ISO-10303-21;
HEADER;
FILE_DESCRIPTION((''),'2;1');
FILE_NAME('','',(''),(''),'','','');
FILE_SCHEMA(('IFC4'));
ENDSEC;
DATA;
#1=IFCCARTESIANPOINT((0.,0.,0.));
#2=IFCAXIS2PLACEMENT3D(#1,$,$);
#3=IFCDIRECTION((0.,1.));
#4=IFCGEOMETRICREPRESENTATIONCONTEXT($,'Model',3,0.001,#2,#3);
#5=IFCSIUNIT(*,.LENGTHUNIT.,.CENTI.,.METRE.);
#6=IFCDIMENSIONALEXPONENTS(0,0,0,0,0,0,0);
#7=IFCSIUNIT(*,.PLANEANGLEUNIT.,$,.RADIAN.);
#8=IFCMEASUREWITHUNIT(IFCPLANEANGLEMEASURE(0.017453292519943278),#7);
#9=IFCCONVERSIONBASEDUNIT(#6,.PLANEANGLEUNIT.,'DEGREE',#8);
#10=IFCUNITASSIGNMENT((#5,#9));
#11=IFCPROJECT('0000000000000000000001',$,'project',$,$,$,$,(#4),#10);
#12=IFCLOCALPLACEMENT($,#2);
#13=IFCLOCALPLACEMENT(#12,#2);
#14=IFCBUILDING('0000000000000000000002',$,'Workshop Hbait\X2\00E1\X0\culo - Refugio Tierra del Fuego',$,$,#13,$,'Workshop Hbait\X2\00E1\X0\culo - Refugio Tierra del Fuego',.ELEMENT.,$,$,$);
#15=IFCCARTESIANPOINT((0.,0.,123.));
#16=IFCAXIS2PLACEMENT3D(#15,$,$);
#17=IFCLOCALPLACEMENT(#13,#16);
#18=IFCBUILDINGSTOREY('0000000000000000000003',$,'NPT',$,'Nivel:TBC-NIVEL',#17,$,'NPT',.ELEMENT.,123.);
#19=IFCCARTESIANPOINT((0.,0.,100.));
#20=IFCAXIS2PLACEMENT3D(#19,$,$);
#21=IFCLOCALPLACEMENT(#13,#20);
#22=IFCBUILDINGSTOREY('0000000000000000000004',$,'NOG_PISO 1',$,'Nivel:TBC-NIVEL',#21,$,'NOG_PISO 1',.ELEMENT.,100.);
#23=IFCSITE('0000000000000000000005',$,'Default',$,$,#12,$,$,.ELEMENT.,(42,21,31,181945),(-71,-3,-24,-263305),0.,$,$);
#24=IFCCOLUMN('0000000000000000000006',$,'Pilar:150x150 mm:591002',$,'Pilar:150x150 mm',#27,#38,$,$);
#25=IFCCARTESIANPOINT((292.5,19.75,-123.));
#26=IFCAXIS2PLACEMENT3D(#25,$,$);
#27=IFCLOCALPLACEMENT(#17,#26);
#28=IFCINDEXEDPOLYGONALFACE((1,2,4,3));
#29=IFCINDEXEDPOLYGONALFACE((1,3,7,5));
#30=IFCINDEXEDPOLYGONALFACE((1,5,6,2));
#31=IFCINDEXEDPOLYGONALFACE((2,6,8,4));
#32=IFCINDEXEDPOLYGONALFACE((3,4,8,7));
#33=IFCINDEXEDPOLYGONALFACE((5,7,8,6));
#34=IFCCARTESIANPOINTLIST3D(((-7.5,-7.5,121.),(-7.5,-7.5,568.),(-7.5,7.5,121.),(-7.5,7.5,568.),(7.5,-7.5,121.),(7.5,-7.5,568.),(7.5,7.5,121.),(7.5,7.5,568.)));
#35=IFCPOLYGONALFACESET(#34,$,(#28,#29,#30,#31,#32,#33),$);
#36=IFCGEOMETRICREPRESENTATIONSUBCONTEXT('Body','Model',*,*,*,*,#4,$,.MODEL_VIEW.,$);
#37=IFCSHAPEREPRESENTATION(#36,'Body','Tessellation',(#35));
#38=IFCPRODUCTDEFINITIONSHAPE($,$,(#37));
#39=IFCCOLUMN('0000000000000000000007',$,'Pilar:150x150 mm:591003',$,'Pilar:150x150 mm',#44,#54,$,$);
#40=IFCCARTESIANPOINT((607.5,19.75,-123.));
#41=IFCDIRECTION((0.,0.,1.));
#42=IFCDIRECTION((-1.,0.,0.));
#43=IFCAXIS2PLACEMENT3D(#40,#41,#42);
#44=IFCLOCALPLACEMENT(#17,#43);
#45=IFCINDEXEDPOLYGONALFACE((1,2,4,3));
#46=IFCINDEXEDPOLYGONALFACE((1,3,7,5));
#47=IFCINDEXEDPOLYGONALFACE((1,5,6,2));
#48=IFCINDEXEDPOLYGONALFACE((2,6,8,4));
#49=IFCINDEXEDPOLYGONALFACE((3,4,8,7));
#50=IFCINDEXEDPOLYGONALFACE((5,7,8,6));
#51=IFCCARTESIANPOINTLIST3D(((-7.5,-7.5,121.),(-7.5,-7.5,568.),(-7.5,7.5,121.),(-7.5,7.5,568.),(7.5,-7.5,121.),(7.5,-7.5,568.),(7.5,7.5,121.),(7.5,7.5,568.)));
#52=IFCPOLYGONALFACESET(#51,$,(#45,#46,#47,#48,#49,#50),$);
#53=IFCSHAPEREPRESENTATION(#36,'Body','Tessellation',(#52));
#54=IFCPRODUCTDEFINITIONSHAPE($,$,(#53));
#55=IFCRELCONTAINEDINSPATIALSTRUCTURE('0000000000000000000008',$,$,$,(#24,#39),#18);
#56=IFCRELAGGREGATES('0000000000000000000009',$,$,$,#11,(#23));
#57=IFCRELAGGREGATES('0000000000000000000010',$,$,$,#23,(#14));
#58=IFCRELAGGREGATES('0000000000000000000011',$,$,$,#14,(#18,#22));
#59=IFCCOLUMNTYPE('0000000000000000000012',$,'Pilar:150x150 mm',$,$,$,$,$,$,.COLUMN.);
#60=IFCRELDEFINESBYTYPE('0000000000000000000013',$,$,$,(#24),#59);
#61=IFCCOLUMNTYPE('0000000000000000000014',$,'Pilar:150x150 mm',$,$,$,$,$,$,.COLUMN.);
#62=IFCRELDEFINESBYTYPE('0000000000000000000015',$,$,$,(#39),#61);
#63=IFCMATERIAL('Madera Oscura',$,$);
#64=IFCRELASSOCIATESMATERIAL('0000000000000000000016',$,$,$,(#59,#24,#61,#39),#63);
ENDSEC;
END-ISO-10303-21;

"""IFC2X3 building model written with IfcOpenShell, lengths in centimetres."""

from ifc_helpers import new_model, entity, si_unit, converted_unit, direction, frame, origin, origin_2d_with_axis, place, context, subcontext, project, spatial, rectangle, extrude, source, transform, mapped, material, type_object, type_shapes, element, save


model = new_model("IFC2X3")

# Units and contexts
model_context = context("Model", 3, precision=0.001, world=origin(), true_north=direction((0.0, 1.0)))
body_context = subcontext(model_context, "Body", "Model", "MODEL_VIEW")
ifc_project = project(units=[si_unit("LENGTHUNIT", "METRE", prefix="CENTI"), converted_unit("PLANEANGLEUNIT", "DEGREE", entity("IfcPlaneAngleMeasure", 0.017453292519943278), si_unit("PLANEANGLEUNIT", "RADIAN"), dimensions=[0, 0, 0, 0, 0, 0, 0])], contexts=[model_context])

# Site, building, storey
site_placement = place(None, origin())
site = spatial("IfcSite", under=ifc_project, at=site_placement, Name="Default", CompositionType="ELEMENT", RefLatitude=(42, 21, 31, 181945), RefLongitude=(-71, -3, -24, -263305), RefElevation=0.0)
building_placement = place(site_placement, origin())
building = spatial("IfcBuilding", under=site, at=building_placement, Name="Workshop Hbaitáculo - Refugio Tierra del Fuego", LongName="Workshop Hbaitáculo - Refugio Tierra del Fuego", CompositionType="ELEMENT")
storey_1_placement = place(building_placement, frame((0.0, 0.0, 123.0)))
storey_1 = spatial("IfcBuildingStorey", under=building, at=storey_1_placement, Name="NPT", ObjectType="Nivel:TBC-NIVEL", LongName="NPT", CompositionType="ELEMENT", Elevation=123.0)

# Columns
ifc_material_1 = material(Name="Madera Oscura")
column_type_1 = type_object("IfcColumnType", Name="Pilar:150x150 mm", PredefinedType="COLUMN", material=ifc_material_1)
shared_shape_1 = source(origin(), body_context, "Body", "SweptSolid", [
    extrude(rectangle(XDim=15.0, YDim=15.0, at=origin_2d_with_axis()), frame((0.0, 0.0, 121.0), z_axis=(0.0, 0.0, 1.0), x_axis=(-1.0, 0.0, 0.0)), (0.0, 0.0, 1.0), 447.0),
])
type_shapes(column_type_1, [shared_shape_1])
column_1_placement = place(storey_1_placement, frame((292.5, 19.75, -123.0)))
element("IfcColumn", 1, at=column_1_placement, inside=storey_1, type_object=column_type_1, material=ifc_material_1, Name="Pilar:150x150 mm:591002", ObjectType="Pilar:150x150 mm", context=body_context, shape_type="MappedRepresentation", body=[
    mapped(shared_shape_1, transform((0.0, 0.0, 0.0), scale=1.0)),
])
column_type_2 = type_object("IfcColumnType", Name="Pilar:150x150 mm", PredefinedType="COLUMN", material=ifc_material_1)
shared_shape_2 = source(origin(), body_context, "Body", "SweptSolid", [
    extrude(rectangle(XDim=15.0, YDim=15.0, at=origin_2d_with_axis()), frame((0.0, 0.0, 121.0), z_axis=(0.0, 0.0, 1.0), x_axis=(0.0, 1.0, 0.0)), (0.0, 0.0, 1.0), 447.0),
])
type_shapes(column_type_2, [shared_shape_2])
column_2_placement = place(storey_1_placement, frame((607.5, 19.75, -123.0), z_axis=(0.0, 0.0, 1.0), x_axis=(-1.0, 0.0, 0.0)))
element("IfcColumn", 2, at=column_2_placement, inside=storey_1, type_object=column_type_2, material=ifc_material_1, Name="Pilar:150x150 mm:591003", ObjectType="Pilar:150x150 mm", context=body_context, shape_type="MappedRepresentation", body=[
    mapped(shared_shape_2, transform((0.0, 0.0, 0.0), scale=1.0)),
])

# Shared definitions
storey_2_placement = place(building_placement, frame((0.0, 0.0, 100.0)))
storey_2 = spatial("IfcBuildingStorey", under=building, at=storey_2_placement, Name="NOG_PISO 1", ObjectType="Nivel:TBC-NIVEL", LongName="NOG_PISO 1", CompositionType="ELEMENT", Elevation=100.0)

save(model, "model.ifc")
